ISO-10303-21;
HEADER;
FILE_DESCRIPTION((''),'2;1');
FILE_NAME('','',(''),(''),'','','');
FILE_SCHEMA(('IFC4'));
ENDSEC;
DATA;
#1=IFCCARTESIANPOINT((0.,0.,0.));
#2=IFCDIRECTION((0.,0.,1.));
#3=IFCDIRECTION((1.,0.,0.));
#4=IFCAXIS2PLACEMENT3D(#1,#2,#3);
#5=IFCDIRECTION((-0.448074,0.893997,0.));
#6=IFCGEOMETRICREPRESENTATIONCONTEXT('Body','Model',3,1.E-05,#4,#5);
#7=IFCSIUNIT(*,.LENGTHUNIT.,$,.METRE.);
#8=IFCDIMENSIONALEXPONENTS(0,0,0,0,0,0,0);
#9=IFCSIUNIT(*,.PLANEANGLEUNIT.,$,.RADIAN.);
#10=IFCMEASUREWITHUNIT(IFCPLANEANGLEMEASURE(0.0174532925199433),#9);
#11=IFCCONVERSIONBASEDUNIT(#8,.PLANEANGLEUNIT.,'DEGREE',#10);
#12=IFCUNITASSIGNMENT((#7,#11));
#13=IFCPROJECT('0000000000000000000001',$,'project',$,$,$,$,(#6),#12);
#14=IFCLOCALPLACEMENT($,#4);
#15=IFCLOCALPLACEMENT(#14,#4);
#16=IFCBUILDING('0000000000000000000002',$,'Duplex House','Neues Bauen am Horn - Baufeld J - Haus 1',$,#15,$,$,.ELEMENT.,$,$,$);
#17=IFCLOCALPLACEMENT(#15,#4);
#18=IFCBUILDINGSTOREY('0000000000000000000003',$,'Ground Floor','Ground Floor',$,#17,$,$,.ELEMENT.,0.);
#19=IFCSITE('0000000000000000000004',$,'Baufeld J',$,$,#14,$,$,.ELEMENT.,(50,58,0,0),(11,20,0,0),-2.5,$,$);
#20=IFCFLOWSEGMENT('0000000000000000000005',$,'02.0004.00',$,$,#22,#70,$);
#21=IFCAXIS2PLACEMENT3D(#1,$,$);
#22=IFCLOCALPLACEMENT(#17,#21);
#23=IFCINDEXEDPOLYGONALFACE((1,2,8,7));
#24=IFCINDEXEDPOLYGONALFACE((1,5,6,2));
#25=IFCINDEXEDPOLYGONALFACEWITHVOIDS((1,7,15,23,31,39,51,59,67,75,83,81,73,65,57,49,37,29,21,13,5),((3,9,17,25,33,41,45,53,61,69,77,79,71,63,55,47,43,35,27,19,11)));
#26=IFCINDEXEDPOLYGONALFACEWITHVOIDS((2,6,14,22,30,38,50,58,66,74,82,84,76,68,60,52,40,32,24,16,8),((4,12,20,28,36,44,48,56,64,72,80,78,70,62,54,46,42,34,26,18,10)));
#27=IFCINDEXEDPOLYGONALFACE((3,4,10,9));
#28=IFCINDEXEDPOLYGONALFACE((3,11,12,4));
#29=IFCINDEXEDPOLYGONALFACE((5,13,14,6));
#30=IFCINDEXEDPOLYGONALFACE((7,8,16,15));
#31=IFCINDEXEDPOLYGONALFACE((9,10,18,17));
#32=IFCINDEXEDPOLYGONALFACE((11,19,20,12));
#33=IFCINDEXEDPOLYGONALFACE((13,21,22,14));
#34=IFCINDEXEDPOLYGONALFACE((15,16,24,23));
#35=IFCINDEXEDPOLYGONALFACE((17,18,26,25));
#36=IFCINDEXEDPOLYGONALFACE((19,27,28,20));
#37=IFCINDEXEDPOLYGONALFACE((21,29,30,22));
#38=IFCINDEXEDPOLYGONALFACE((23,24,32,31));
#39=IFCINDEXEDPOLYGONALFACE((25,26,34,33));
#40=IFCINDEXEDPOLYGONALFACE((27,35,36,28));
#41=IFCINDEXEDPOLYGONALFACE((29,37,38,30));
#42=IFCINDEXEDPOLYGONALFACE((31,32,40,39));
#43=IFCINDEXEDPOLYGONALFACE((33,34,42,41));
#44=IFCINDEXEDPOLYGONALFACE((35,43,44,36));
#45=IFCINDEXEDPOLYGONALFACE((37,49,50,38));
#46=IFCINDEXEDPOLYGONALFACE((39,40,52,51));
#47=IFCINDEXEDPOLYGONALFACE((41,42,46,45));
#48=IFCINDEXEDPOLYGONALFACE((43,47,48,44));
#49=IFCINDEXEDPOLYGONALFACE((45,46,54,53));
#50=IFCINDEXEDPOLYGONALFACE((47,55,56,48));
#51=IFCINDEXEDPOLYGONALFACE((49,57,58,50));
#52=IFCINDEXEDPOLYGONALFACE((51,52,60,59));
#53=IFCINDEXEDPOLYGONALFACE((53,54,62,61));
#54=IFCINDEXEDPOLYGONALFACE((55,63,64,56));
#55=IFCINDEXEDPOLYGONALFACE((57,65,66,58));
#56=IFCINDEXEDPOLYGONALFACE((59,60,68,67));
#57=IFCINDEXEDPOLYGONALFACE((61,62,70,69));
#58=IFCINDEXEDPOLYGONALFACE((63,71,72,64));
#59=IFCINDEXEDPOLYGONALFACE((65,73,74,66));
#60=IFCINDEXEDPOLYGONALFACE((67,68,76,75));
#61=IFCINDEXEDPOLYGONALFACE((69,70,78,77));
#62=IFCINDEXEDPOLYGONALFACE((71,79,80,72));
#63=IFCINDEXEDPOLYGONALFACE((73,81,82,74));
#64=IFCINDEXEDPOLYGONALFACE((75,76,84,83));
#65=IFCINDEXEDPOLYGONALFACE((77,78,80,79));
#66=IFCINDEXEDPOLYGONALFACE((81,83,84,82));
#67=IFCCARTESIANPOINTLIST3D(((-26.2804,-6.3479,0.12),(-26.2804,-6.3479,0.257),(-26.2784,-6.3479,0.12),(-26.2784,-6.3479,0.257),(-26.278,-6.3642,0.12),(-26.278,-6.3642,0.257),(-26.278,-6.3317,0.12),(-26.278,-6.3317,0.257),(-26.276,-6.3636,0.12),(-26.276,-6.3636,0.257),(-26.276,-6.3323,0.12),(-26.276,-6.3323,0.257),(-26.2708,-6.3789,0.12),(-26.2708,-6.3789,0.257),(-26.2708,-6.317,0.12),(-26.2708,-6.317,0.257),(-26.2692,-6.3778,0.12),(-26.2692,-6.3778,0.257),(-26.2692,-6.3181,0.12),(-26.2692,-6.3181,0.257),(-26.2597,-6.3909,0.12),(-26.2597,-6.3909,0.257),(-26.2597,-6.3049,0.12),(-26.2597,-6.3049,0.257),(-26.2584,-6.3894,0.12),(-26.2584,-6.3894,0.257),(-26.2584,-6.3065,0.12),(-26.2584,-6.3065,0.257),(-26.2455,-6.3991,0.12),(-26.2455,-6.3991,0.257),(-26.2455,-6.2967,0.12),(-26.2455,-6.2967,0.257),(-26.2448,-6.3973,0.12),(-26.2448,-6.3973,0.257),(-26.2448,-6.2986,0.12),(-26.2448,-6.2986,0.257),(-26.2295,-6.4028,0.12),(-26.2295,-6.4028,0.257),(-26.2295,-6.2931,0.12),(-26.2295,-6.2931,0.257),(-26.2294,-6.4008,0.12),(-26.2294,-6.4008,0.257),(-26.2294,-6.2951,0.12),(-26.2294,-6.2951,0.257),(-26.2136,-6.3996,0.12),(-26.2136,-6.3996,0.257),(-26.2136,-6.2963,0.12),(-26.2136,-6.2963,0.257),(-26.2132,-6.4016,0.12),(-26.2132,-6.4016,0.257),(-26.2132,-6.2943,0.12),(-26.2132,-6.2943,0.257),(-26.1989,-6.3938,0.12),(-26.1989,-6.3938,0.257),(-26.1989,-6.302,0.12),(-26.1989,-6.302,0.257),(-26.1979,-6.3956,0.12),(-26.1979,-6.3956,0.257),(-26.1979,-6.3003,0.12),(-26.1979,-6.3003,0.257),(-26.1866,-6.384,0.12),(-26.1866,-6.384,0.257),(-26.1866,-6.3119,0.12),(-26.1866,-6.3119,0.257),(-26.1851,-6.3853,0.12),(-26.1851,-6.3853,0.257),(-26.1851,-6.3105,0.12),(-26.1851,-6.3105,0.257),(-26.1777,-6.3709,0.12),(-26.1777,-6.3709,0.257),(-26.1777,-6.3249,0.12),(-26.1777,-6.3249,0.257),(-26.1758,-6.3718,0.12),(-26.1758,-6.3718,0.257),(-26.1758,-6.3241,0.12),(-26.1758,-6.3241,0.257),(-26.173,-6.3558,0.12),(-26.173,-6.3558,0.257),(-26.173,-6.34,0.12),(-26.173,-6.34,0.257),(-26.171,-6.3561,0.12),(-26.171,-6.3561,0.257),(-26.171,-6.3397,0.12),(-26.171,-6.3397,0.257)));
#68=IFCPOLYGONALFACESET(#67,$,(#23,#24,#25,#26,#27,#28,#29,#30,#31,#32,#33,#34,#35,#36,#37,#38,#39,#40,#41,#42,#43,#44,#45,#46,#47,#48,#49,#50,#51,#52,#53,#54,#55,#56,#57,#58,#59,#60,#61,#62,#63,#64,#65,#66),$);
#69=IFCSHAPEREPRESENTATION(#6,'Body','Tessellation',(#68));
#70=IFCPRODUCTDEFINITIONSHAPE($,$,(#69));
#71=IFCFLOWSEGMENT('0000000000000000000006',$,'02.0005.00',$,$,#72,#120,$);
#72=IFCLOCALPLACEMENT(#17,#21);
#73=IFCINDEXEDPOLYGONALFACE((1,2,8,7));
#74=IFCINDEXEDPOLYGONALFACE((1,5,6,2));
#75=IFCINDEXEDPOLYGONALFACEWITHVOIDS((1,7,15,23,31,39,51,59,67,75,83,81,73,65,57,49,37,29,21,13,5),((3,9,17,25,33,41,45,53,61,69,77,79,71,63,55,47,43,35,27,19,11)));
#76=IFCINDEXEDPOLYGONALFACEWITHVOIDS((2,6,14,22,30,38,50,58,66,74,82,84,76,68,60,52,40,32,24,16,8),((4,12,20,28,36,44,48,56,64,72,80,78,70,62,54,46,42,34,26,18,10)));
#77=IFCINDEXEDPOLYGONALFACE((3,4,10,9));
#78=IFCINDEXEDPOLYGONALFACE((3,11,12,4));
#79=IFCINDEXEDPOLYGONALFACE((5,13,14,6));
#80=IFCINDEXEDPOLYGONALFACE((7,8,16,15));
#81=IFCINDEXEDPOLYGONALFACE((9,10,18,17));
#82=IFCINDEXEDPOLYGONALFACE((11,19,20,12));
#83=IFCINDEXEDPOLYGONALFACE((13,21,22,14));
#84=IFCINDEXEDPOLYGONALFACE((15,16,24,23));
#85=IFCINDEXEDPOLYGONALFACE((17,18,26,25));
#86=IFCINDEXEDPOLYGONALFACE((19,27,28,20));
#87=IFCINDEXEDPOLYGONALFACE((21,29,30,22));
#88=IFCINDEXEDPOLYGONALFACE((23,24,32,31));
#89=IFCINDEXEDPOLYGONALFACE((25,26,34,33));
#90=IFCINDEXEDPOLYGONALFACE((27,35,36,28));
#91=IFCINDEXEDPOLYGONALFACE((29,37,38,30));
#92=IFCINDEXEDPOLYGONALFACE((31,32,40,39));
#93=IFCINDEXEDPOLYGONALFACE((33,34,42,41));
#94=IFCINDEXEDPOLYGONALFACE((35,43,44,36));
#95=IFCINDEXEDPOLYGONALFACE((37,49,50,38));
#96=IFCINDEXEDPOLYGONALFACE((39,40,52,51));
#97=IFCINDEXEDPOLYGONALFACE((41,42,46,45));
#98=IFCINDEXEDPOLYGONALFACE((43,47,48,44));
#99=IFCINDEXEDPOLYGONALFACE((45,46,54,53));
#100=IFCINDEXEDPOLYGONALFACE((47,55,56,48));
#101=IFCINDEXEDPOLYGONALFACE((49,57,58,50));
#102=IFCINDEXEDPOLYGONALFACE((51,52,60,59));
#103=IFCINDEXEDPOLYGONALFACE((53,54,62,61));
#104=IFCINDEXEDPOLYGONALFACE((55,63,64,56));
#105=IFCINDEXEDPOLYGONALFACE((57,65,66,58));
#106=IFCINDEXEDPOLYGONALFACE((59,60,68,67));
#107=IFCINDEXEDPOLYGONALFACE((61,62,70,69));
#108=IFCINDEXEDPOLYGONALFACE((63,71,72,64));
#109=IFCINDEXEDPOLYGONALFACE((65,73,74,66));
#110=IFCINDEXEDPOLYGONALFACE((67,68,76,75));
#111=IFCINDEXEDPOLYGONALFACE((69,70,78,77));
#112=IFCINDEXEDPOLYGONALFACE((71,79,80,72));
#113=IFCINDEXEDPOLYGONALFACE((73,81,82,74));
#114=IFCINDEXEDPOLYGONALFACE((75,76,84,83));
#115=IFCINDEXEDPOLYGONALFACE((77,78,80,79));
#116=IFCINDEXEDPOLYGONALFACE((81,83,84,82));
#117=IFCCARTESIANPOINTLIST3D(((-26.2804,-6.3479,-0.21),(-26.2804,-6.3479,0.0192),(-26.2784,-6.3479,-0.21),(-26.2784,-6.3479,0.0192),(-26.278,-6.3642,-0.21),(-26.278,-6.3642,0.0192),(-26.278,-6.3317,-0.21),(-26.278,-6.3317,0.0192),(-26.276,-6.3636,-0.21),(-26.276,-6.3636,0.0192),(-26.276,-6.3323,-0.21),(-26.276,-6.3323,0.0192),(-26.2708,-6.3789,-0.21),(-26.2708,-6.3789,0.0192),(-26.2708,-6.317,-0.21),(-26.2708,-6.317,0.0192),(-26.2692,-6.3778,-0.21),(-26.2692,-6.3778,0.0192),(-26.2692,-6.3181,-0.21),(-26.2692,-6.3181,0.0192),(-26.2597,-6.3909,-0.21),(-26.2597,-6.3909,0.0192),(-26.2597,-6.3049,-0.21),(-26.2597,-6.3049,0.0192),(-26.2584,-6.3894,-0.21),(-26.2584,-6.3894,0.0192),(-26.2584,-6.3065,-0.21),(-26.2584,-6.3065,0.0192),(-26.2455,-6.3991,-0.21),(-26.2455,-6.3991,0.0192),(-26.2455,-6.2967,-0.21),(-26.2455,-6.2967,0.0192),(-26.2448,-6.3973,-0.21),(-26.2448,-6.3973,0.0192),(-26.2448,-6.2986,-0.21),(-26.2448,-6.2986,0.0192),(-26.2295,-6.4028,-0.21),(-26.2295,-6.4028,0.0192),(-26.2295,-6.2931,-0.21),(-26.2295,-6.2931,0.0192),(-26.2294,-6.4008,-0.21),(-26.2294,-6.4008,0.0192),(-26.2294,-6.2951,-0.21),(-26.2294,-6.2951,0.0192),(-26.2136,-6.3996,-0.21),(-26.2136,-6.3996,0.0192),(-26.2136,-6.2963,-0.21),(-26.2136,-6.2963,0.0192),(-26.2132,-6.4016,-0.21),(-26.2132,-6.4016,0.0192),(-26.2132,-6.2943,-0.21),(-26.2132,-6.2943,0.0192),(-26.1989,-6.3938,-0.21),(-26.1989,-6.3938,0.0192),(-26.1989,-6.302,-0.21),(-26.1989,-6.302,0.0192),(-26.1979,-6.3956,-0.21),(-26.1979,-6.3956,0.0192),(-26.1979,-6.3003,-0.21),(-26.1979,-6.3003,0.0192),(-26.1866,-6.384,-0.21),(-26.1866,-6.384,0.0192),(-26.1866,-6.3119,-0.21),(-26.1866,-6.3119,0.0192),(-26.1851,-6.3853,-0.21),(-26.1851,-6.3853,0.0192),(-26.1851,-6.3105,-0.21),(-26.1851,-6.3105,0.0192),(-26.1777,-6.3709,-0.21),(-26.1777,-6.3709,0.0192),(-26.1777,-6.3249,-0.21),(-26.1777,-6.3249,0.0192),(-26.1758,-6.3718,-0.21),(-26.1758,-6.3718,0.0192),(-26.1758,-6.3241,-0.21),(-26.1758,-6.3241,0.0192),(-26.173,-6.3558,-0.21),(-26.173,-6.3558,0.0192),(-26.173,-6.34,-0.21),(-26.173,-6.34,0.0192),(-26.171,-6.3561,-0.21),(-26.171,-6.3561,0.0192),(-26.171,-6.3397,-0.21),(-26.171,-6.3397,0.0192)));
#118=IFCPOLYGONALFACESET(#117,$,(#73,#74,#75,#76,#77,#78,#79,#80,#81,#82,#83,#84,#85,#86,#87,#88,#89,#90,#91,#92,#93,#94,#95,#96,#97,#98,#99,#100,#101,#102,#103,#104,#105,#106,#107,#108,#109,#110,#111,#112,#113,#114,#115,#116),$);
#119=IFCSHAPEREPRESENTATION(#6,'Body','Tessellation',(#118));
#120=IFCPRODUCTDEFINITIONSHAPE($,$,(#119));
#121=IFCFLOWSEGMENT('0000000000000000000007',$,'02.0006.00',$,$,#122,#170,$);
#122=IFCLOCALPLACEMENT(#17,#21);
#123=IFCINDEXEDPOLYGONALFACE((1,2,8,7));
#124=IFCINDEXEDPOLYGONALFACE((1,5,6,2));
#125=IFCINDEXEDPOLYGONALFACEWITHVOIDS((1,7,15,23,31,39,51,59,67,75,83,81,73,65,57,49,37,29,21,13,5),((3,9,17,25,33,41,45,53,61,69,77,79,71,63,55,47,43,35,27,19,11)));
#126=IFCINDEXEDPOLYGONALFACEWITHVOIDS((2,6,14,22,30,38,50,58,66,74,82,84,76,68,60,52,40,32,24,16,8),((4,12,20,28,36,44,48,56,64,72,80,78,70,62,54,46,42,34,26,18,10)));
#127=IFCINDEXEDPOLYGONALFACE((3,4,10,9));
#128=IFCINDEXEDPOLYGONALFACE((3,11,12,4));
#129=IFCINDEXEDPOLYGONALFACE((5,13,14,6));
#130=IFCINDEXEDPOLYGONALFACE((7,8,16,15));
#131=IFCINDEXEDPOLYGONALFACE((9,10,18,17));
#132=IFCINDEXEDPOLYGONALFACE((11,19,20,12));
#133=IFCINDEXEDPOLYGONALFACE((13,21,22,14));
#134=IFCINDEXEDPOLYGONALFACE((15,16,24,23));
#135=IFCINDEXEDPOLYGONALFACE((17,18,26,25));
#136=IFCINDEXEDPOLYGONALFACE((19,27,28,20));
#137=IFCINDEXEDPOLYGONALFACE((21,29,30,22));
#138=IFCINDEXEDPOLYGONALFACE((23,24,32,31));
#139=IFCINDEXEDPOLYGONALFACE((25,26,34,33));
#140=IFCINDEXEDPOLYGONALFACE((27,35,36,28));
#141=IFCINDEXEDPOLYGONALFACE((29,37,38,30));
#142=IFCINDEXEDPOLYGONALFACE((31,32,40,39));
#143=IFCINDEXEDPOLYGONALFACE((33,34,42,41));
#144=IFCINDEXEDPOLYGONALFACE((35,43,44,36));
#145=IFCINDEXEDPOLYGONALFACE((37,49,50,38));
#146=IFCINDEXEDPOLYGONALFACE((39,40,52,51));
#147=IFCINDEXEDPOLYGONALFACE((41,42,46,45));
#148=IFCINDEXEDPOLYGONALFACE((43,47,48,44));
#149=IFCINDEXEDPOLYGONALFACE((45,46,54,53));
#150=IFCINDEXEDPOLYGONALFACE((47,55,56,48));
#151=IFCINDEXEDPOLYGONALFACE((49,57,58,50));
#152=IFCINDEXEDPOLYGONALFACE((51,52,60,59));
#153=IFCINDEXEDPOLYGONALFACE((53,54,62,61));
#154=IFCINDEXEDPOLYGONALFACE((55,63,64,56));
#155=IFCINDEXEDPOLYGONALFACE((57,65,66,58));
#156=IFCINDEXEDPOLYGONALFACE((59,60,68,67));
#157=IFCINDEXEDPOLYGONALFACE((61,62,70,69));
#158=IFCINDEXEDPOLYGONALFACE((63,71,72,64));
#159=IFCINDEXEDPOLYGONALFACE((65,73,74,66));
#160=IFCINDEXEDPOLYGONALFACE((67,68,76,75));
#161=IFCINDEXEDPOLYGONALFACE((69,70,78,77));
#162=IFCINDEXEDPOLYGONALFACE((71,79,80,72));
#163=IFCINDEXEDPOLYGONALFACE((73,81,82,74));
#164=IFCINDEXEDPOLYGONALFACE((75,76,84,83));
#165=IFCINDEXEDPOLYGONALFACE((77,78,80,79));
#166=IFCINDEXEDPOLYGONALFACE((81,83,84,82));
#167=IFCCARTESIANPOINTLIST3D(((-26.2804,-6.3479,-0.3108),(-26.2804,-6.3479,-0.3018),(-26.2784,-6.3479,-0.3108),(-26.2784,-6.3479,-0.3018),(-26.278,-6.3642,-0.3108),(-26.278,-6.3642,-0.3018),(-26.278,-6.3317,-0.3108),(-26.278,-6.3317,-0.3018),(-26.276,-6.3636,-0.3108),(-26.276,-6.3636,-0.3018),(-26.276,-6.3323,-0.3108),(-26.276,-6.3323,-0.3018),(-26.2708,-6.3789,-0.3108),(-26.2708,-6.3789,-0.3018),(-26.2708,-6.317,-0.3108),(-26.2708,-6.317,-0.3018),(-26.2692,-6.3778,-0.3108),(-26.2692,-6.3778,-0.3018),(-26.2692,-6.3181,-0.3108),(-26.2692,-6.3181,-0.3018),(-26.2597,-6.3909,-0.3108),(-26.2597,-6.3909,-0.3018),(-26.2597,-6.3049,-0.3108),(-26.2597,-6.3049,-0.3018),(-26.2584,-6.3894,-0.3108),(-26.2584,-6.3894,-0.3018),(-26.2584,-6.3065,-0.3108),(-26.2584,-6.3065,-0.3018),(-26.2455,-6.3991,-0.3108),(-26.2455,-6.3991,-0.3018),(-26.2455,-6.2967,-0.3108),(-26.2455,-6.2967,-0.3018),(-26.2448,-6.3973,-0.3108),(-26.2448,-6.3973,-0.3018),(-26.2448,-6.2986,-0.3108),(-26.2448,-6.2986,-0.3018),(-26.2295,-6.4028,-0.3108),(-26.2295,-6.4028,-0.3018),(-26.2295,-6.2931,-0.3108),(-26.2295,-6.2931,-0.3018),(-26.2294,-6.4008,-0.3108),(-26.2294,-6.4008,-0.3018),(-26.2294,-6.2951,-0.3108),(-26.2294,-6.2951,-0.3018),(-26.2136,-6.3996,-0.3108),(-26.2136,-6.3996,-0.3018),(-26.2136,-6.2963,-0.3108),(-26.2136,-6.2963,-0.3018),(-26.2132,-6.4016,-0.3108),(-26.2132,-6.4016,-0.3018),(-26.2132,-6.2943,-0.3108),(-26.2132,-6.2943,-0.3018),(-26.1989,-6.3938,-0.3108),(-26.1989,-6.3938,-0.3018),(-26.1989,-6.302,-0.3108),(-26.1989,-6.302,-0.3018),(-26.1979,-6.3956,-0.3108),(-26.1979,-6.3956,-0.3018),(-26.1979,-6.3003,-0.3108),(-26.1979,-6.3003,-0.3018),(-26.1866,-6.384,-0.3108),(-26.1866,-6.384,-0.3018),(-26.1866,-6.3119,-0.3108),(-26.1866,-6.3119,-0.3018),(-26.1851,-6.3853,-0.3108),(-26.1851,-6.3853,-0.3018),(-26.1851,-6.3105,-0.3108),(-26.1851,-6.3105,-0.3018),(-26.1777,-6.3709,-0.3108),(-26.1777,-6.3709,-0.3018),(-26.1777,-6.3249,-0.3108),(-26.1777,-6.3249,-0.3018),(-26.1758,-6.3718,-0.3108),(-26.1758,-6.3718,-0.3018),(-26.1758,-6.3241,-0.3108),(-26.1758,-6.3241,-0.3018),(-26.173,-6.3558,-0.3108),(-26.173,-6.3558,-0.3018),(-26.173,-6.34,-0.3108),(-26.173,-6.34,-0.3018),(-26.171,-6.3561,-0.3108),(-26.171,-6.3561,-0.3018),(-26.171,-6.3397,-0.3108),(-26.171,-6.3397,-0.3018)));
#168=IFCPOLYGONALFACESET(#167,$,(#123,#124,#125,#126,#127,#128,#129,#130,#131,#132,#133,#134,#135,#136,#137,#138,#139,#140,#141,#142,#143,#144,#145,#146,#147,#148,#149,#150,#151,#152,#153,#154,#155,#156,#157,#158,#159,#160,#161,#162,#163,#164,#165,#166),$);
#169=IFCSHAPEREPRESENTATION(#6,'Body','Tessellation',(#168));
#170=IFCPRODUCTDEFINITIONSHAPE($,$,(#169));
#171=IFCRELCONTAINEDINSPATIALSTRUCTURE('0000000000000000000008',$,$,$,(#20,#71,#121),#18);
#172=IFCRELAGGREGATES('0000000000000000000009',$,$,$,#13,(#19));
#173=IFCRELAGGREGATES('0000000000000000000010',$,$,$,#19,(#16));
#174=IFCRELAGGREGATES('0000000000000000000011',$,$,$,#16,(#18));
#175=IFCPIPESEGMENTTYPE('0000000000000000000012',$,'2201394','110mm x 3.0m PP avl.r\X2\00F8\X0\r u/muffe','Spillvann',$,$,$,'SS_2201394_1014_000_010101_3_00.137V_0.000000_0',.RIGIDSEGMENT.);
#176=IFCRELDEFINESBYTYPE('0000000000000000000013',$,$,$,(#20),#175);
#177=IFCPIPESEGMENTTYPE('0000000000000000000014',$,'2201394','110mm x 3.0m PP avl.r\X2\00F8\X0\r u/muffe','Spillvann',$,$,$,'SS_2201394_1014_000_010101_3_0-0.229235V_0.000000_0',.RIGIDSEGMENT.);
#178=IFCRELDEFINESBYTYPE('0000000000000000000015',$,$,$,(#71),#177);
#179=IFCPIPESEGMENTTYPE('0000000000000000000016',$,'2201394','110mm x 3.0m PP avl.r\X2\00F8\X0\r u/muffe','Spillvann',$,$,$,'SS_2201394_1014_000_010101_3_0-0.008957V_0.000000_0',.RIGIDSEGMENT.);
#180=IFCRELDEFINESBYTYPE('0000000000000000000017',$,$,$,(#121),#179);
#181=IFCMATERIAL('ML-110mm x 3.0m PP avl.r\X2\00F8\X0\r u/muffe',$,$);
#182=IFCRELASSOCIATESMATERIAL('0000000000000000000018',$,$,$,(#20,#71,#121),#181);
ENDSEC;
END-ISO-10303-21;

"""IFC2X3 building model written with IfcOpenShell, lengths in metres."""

from ifc_helpers import new_model, entity, si_unit, converted_unit, direction, frame, origin_with_axes, origin_2d_with_axis, place, context, project, spatial, hollow_circle, extrude, material, type_object, element, save


model = new_model("IFC2X3")

# Units and contexts
model_context = context("Model", 3, precision=1e-05, world=origin_with_axes(), true_north=direction((-0.448074, 0.893997, 0.0)), identifier="Body")
ifc_project = project(units=[si_unit("LENGTHUNIT", "METRE"), converted_unit("PLANEANGLEUNIT", "DEGREE", entity("IfcPlaneAngleMeasure", 0.0174532925199433), si_unit("PLANEANGLEUNIT", "RADIAN"), dimensions=[0, 0, 0, 0, 0, 0, 0])], contexts=[model_context])

# Site, building, storey
site_placement = place(None, origin_with_axes())
site = spatial("IfcSite", under=ifc_project, at=site_placement, Name="Baufeld J", CompositionType="ELEMENT", RefLatitude=(50, 58, 0, 0), RefLongitude=(11, 20, 0, 0), RefElevation=-2.5)
building_placement = place(site_placement, origin_with_axes())
building = spatial("IfcBuilding", under=site, at=building_placement, Name="Duplex House", Description="Neues Bauen am Horn - Baufeld J - Haus 1", CompositionType="ELEMENT")
storey_placement = place(building_placement, origin_with_axes())
storey = spatial("IfcBuildingStorey", under=building, at=storey_placement, Name="Ground Floor", Description="Ground Floor", CompositionType="ELEMENT", Elevation=0.0)

# Flow segments
ifc_material_1 = material(Name="ML-110mm x 3.0m PP avl.rør u/muffe")
pipe_segment_type_1 = type_object("IfcPipeSegmentType", Name="2201394", Description="110mm x 3.0m PP avl.rør u/muffe", ApplicableOccurrence="Spillvann", ElementType="SS_2201394_1014_000_010101_3_00.137V_0.000000_0", PredefinedType="RIGIDSEGMENT")
flow_segment_1_placement = place(storey_placement, frame((-26.2254, -6.3479, 0.257), z_axis=(1.0, 0.0, 0.0), x_axis=(0.0, 0.0, -1.0)))
element("IfcFlowSegment", 1, at=flow_segment_1_placement, inside=storey, type_object=pipe_segment_type_1, material=ifc_material_1, Name="02.0004.00", context=model_context, shape_type="SweptSolid", body=[
    extrude(hollow_circle(Radius=0.055, WallThickness=0.002, at=origin_2d_with_axis()), frame((0.0, 0.0, 0.0), z_axis=(1.0, 0.0, 0.0), x_axis=(0.0, 0.0, -1.0)), (0.0, 0.0, 1.0), 0.137),
])
pipe_segment_type_2 = type_object("IfcPipeSegmentType", Name="2201394", Description="110mm x 3.0m PP avl.rør u/muffe", ApplicableOccurrence="Spillvann", ElementType="SS_2201394_1014_000_010101_3_0-0.229235V_0.000000_0", PredefinedType="RIGIDSEGMENT")
flow_segment_2_placement = place(storey_placement, frame((-26.2254, -6.3479, -0.21), z_axis=(1.0, 0.0, 0.0), x_axis=(0.0, 0.0, -1.0)))
element("IfcFlowSegment", 2, at=flow_segment_2_placement, inside=storey, type_object=pipe_segment_type_2, material=ifc_material_1, Name="02.0005.00", context=model_context, shape_type="SweptSolid", body=[
    extrude(hollow_circle(Radius=0.055, WallThickness=0.002, at=origin_2d_with_axis()), frame((0.0, 0.0, 0.0), z_axis=(1.0, 0.0, 0.0), x_axis=(0.0, 0.0, -1.0)), (0.0, 0.0, -1.0), 0.2292),
])
pipe_segment_type_3 = type_object("IfcPipeSegmentType", Name="2201394", Description="110mm x 3.0m PP avl.rør u/muffe", ApplicableOccurrence="Spillvann", ElementType="SS_2201394_1014_000_010101_3_0-0.008957V_0.000000_0", PredefinedType="RIGIDSEGMENT")
flow_segment_3_placement = place(storey_placement, frame((-26.2254, -6.3479, -0.3108), z_axis=(1.0, 0.0, 0.0), x_axis=(0.0, 0.0, -1.0)))
element("IfcFlowSegment", 3, at=flow_segment_3_placement, inside=storey, type_object=pipe_segment_type_3, material=ifc_material_1, Name="02.0006.00", context=model_context, shape_type="SweptSolid", body=[
    extrude(hollow_circle(Radius=0.055, WallThickness=0.002, at=origin_2d_with_axis()), frame((0.0, 0.0, 0.0), z_axis=(1.0, 0.0, 0.0), x_axis=(0.0, 0.0, -1.0)), (0.0, 0.0, -1.0), 0.009),
])

save(model, "model.ifc")
